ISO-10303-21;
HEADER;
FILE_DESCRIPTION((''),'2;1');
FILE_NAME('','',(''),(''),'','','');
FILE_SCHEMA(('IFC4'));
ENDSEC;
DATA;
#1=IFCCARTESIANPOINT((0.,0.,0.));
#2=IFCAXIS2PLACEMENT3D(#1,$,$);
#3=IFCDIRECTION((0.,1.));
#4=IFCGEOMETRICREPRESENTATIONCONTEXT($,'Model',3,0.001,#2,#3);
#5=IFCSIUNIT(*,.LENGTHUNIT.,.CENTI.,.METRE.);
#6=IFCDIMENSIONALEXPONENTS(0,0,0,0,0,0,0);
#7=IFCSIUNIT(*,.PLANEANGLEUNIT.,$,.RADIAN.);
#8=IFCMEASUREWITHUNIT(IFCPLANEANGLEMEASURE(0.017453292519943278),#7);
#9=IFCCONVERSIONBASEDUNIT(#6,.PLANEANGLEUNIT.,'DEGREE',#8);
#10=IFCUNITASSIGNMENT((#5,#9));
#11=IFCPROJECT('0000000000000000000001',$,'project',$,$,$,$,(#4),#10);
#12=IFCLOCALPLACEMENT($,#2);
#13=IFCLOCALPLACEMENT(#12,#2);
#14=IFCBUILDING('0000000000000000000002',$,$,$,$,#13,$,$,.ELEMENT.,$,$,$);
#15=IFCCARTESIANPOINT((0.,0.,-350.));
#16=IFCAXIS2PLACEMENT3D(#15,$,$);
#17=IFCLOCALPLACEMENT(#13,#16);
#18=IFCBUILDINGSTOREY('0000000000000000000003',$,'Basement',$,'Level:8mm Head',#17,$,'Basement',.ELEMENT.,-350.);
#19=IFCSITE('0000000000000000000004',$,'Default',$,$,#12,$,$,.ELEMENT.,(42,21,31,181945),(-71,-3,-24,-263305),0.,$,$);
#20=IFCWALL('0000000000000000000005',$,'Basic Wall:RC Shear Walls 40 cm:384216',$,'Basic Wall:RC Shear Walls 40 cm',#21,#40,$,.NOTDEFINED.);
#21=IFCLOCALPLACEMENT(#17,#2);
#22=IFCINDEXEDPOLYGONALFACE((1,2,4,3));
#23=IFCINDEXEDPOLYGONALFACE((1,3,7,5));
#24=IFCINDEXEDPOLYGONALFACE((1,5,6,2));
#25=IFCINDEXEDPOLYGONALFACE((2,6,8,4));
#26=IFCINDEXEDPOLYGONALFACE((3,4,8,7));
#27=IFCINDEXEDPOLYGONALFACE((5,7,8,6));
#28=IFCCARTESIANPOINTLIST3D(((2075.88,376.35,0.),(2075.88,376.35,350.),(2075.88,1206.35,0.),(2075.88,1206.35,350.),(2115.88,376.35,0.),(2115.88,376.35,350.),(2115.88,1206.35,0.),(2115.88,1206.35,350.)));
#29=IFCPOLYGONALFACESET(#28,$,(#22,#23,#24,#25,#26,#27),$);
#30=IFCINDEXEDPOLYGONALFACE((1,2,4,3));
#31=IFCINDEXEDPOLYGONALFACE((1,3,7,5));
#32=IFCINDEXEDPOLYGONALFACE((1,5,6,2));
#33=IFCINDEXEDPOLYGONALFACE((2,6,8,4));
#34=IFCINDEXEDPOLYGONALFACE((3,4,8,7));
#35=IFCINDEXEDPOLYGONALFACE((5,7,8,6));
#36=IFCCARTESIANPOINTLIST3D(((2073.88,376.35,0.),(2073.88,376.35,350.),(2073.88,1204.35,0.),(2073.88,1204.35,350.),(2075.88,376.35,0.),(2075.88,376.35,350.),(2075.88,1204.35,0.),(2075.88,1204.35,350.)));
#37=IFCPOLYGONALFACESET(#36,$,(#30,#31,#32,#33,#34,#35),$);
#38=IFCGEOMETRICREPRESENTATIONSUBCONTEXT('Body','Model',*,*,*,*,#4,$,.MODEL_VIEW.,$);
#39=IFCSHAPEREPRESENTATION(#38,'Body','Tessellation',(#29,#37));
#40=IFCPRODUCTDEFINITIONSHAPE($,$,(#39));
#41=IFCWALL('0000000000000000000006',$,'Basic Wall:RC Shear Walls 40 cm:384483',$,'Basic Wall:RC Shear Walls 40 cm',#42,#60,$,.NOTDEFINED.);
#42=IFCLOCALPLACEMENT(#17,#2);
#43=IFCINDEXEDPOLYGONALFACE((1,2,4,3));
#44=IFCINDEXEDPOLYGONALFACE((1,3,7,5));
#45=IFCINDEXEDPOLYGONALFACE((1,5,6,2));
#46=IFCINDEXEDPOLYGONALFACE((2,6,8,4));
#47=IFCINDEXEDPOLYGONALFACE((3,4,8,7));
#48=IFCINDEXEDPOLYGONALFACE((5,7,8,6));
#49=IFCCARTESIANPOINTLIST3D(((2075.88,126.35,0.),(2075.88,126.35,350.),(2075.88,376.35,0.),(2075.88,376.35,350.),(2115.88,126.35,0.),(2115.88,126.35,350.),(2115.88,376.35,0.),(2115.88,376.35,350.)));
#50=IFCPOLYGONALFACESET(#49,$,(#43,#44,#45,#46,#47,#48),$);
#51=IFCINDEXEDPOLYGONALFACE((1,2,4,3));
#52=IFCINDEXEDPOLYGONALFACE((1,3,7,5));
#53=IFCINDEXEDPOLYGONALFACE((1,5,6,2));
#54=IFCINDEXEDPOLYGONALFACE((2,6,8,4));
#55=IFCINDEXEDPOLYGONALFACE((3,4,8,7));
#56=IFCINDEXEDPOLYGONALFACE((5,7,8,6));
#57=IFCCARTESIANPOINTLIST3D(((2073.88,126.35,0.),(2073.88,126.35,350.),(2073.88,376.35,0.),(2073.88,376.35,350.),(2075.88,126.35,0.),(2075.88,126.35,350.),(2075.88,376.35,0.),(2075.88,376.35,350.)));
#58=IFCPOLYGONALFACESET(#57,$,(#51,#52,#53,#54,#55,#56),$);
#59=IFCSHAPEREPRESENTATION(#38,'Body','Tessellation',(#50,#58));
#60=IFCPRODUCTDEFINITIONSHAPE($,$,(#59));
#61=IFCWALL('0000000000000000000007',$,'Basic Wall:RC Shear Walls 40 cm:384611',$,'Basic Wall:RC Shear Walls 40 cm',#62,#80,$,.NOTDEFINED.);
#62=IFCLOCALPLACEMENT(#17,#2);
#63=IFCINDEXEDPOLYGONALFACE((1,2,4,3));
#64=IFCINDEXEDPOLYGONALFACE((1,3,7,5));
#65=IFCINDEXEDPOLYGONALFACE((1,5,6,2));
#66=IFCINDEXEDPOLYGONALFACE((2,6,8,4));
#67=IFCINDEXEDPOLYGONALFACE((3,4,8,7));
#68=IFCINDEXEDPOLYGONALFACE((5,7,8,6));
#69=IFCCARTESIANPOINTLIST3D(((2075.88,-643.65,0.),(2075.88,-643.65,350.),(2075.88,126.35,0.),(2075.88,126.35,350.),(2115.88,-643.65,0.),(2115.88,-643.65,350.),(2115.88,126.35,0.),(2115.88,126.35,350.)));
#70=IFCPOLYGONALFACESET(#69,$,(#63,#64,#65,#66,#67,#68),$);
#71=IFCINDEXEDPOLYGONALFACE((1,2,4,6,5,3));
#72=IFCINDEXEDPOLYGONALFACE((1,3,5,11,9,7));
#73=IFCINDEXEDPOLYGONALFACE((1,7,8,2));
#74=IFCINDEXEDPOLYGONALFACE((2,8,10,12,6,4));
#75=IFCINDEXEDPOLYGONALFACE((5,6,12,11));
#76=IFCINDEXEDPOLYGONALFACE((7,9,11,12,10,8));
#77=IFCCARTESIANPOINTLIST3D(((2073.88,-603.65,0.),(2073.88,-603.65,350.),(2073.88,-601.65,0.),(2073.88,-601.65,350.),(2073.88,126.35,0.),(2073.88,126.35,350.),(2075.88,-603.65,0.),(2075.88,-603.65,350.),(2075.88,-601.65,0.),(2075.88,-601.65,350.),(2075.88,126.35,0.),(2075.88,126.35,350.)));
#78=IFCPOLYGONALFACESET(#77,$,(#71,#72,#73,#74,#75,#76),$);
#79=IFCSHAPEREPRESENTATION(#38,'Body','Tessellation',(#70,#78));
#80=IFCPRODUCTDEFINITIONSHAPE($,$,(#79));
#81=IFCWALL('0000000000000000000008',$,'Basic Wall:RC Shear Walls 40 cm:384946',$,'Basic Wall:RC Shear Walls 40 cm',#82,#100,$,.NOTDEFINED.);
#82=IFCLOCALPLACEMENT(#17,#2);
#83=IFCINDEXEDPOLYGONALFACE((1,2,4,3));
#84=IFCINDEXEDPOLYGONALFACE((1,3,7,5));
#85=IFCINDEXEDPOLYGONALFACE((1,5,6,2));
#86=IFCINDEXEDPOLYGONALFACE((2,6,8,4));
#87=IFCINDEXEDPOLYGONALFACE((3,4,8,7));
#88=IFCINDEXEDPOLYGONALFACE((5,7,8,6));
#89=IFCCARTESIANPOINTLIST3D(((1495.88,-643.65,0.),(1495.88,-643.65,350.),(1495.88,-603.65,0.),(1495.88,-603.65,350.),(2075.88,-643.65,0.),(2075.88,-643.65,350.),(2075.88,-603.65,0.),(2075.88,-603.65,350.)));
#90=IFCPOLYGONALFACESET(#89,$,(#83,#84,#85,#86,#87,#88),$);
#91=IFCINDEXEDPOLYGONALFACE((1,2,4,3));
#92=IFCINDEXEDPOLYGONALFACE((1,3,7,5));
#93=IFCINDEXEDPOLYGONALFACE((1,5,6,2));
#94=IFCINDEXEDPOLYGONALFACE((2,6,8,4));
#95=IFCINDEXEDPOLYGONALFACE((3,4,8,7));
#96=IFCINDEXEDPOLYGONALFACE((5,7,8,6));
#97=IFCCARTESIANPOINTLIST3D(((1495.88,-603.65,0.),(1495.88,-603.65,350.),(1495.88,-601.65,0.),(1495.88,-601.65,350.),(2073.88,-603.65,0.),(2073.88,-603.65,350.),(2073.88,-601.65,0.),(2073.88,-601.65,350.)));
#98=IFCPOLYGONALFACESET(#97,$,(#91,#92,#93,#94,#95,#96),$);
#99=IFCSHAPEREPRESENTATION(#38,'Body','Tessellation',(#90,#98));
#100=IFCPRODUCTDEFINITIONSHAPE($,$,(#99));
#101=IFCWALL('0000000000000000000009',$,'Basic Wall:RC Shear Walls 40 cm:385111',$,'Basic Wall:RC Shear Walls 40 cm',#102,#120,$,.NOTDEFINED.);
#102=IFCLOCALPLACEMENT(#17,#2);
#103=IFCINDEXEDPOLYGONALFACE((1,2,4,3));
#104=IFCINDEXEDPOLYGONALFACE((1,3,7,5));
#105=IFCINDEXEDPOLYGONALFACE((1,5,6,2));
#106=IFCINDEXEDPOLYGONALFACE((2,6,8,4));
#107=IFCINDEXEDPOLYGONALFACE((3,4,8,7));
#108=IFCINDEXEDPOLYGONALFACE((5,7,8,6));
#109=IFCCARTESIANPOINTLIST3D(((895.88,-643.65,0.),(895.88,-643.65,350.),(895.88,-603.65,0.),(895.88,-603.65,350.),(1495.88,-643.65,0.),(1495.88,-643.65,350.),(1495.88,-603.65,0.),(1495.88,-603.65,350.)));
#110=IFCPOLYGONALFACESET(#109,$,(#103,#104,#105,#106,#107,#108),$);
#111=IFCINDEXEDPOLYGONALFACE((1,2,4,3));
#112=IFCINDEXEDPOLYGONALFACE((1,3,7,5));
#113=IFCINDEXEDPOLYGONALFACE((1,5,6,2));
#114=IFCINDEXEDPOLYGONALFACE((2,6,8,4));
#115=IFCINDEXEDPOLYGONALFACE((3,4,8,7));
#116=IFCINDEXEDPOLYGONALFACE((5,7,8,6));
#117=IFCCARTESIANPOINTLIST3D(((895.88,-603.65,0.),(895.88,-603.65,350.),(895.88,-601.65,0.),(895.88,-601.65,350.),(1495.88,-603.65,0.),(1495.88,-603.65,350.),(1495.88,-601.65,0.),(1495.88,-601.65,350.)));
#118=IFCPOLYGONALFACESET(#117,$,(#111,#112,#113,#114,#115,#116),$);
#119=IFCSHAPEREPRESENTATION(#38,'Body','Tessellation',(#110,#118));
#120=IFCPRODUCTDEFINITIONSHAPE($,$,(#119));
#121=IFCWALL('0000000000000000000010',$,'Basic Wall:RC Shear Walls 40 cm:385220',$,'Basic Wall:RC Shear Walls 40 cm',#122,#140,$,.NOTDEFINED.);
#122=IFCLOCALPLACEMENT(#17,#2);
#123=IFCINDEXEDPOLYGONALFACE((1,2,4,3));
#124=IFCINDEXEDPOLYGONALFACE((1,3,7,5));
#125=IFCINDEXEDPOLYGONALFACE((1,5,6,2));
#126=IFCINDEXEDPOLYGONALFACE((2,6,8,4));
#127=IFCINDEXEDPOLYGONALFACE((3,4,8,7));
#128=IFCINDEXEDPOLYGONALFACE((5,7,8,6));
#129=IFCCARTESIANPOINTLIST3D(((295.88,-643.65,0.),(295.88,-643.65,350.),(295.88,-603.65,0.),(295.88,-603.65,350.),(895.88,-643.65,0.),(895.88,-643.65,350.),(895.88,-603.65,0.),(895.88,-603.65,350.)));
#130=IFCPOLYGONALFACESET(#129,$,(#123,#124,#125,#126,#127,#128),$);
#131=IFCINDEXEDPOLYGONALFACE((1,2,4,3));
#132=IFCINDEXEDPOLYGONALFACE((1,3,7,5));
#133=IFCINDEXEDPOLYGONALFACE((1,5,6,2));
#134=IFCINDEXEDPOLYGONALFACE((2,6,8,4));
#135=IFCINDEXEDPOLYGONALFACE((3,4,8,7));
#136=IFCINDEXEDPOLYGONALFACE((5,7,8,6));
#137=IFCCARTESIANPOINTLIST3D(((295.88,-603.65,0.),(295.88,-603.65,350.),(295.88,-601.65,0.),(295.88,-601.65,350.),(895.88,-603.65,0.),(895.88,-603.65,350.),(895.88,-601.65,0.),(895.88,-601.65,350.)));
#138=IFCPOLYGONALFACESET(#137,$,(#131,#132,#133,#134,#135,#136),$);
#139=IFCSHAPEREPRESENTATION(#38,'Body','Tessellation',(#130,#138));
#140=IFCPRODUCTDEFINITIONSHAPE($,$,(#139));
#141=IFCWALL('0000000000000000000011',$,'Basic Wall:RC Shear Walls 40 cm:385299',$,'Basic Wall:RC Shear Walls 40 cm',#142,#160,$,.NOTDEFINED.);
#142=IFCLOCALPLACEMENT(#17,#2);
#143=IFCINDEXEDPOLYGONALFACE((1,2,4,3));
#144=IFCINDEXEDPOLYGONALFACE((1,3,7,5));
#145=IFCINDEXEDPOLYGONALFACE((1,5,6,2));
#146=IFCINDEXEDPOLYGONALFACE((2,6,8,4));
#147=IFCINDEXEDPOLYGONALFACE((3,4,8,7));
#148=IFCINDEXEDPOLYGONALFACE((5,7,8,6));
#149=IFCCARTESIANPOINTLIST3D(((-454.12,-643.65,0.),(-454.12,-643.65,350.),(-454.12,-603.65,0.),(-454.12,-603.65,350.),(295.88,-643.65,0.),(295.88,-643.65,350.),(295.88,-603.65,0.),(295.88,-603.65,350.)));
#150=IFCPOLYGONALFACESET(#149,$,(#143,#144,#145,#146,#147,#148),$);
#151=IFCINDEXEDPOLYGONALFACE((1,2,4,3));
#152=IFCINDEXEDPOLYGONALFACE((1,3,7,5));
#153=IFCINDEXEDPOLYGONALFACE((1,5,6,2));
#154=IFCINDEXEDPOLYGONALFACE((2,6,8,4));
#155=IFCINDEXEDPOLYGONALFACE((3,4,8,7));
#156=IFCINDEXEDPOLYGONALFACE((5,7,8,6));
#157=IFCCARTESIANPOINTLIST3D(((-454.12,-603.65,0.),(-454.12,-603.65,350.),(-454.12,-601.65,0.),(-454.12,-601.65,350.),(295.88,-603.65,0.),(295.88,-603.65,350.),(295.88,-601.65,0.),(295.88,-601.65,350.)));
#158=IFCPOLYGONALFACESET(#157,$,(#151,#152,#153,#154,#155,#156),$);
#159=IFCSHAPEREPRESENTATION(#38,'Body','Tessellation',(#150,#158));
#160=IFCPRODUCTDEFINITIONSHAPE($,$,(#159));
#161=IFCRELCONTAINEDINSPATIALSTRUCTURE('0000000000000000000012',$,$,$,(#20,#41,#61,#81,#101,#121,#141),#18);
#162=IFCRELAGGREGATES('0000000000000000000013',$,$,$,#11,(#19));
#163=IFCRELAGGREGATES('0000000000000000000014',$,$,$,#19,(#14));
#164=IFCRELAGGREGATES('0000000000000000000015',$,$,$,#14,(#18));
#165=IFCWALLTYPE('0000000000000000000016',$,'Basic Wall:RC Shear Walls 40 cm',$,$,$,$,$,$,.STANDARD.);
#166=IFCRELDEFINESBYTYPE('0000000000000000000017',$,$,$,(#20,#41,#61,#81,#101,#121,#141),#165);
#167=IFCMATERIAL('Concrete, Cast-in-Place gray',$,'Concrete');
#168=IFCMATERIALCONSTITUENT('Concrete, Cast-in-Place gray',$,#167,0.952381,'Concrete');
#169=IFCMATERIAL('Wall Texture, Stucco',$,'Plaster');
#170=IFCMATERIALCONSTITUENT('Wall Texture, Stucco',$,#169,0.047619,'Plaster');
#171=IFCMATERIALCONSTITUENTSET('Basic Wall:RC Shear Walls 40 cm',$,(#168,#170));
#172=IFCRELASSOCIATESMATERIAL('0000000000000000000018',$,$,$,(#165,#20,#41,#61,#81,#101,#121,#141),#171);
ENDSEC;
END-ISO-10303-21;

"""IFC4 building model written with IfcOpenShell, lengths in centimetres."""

from ifc_helpers import new_model, entity, si_unit, converted_unit, direction, frame, origin, place, context, subcontext, project, spatial, indexed_curve, outline, extrude, material, constituent, constituent_set, type_object, element, save


model = new_model("IFC4")

# Units and contexts
model_context = context("Model", 3, precision=0.001, world=origin(), true_north=direction((0.0, 1.0)))
body_context = subcontext(model_context, "Body", "Model", "MODEL_VIEW")
ifc_project = project(units=[si_unit("LENGTHUNIT", "METRE", prefix="CENTI"), converted_unit("PLANEANGLEUNIT", "DEGREE", entity("IfcPlaneAngleMeasure", 0.017453292519943278), si_unit("PLANEANGLEUNIT", "RADIAN"), dimensions=[0, 0, 0, 0, 0, 0, 0])], contexts=[model_context])

# Site, building, storey
site_placement = place(None, origin())
site = spatial("IfcSite", under=ifc_project, at=site_placement, Name="Default", CompositionType="ELEMENT", RefLatitude=(42, 21, 31, 181945), RefLongitude=(-71, -3, -24, -263305), RefElevation=0.0)
building_placement = place(site_placement, origin())
building = spatial("IfcBuilding", under=site, at=building_placement, CompositionType="ELEMENT")
storey_placement = place(building_placement, frame((0.0, 0.0, -350.0)))
storey = spatial("IfcBuildingStorey", under=building, at=storey_placement, Name="Basement", ObjectType="Level:8mm Head", LongName="Basement", CompositionType="ELEMENT", Elevation=-350.0)

# Shared definitions
ifc_material_1 = material(Name="Concrete, Cast-in-Place gray", Category="Concrete")

# Walls
ifc_constituent_1 = constituent(ifc_material_1, Name="Concrete, Cast-in-Place gray", Category="Concrete", fraction=0.952381)
ifc_material_2 = material(Name="Wall Texture, Stucco", Category="Plaster")
ifc_constituent_2 = constituent(ifc_material_2, Name="Wall Texture, Stucco", Category="Plaster", fraction=0.047619)
ifc_constituent_set_1 = constituent_set(constituents=[ifc_constituent_1, ifc_constituent_2], Name="Basic Wall:RC Shear Walls 40 cm")
wall_type_1 = type_object("IfcWallType", Name="Basic Wall:RC Shear Walls 40 cm", PredefinedType="STANDARD", material=ifc_constituent_set_1)
wall_1_placement = place(storey_placement, frame((2094.88, 1204.35, 0.0), z_axis=(0.0, 0.0, 1.0), x_axis=(0.0, -1.0, 0.0)))
element("IfcWall", 1, at=wall_1_placement, inside=storey, type_object=wall_type_1, material=ifc_constituent_set_1, Name="Basic Wall:RC Shear Walls 40 cm:384216", ObjectType="Basic Wall:RC Shear Walls 40 cm", PredefinedType="NOTDEFINED", context=body_context, shape_type="SweptSolid", body=[
    extrude(outline(indexed_curve([(-20.0, -415.0), (20.0, -415.0), (20.0, 415.0), (-20.0, 415.0), (-20.0, -415.0)], self_intersect=False)), frame((413.0, 1.0, 0.0), z_axis=(0.0, 0.0, 1.0), x_axis=(0.0, -1.0, 0.0)), (0.0, 0.0, 1.0), 350.0),
    extrude(outline(indexed_curve([(-1.0, -414.0), (1.0, -414.0), (1.0, 414.0), (-1.0, 414.0), (-1.0, -414.0)], self_intersect=False)), frame((414.0, -20.0, 0.0), z_axis=(0.0, 0.0, 1.0), x_axis=(0.0, 1.0, 0.0)), (0.0, 0.0, 1.0), 350.0),
])
wall_2_placement = place(storey_placement, frame((2094.88, 376.35, 0.0), z_axis=(0.0, 0.0, 1.0), x_axis=(0.0, -1.0, 0.0)))
element("IfcWall", 2, at=wall_2_placement, inside=storey, type_object=wall_type_1, material=ifc_constituent_set_1, Name="Basic Wall:RC Shear Walls 40 cm:384483", ObjectType="Basic Wall:RC Shear Walls 40 cm", PredefinedType="NOTDEFINED", context=body_context, shape_type="SweptSolid", body=[
    extrude(outline(indexed_curve([(-20.0, -125.0), (20.0, -125.0), (20.0, 125.0), (-20.0, 125.0), (-20.0, -125.0)], self_intersect=False)), frame((125.0, 1.0, 0.0), z_axis=(0.0, 0.0, 1.0), x_axis=(0.0, -1.0, 0.0)), (0.0, 0.0, 1.0), 350.0),
    extrude(outline(indexed_curve([(-1.0, -125.0), (1.0, -125.0), (1.0, 125.0), (-1.0, 125.0), (-1.0, -125.0)], self_intersect=False)), frame((125.0, -20.0, 0.0), z_axis=(0.0, 0.0, 1.0), x_axis=(0.0, 1.0, 0.0)), (0.0, 0.0, 1.0), 350.0),
])
wall_3_placement = place(storey_placement, frame((2094.88, 126.35, 0.0), z_axis=(0.0, 0.0, 1.0), x_axis=(0.0, -1.0, 0.0)))
element("IfcWall", 3, at=wall_3_placement, inside=storey, type_object=wall_type_1, material=ifc_constituent_set_1, Name="Basic Wall:RC Shear Walls 40 cm:384611", ObjectType="Basic Wall:RC Shear Walls 40 cm", PredefinedType="NOTDEFINED", context=body_context, shape_type="SweptSolid", body=[
    extrude(outline(indexed_curve([(-20.0, -385.0), (20.0, -385.0), (20.0, 385.0), (-20.0, 385.0), (-20.0, -385.0)], self_intersect=False)), frame((385.0, 1.0, 0.0), z_axis=(0.0, 0.0, 1.0), x_axis=(0.0, -1.0, 0.0)), (0.0, 0.0, 1.0), 350.0),
    extrude(outline(indexed_curve([(-175.0, -486.0), (175.0, -486.0), (175.0, 242.0), (175.0, 244.0), (-175.0, 244.0), (-175.0, 242.0), (-175.0, -486.0)], self_intersect=False)), frame((486.0, -21.0, 175.0), z_axis=(0.0, 1.0, 0.0), x_axis=(0.0, 0.0, 1.0)), (0.0, 0.0, 1.0), 2.0),
])
wall_4_placement = place(storey_placement, frame((2073.88, -622.65, 0.0), z_axis=(0.0, 0.0, 1.0), x_axis=(-1.0, 0.0, 0.0)))
element("IfcWall", 4, at=wall_4_placement, inside=storey, type_object=wall_type_1, material=ifc_constituent_set_1, Name="Basic Wall:RC Shear Walls 40 cm:384946", ObjectType="Basic Wall:RC Shear Walls 40 cm", PredefinedType="NOTDEFINED", context=body_context, shape_type="SweptSolid", body=[
    extrude(outline(indexed_curve([(-20.0, -290.0), (20.0, -290.0), (20.0, 290.0), (-20.0, 290.0), (-20.0, -290.0)], self_intersect=False)), frame((288.0, 1.0, 0.0), z_axis=(0.0, 0.0, 1.0), x_axis=(0.0, -1.0, 0.0)), (0.0, 0.0, 1.0), 350.0),
    extrude(outline(indexed_curve([(-1.0, -289.0), (1.0, -289.0), (1.0, 289.0), (-1.0, 289.0), (-1.0, -289.0)], self_intersect=False)), frame((289.0, -20.0, 0.0), z_axis=(0.0, 0.0, 1.0), x_axis=(0.0, 1.0, 0.0)), (0.0, 0.0, 1.0), 350.0),
])
wall_5_placement = place(storey_placement, frame((1495.88, -622.65, 0.0), z_axis=(0.0, 0.0, 1.0), x_axis=(-1.0, 0.0, 0.0)))
element("IfcWall", 5, at=wall_5_placement, inside=storey, type_object=wall_type_1, material=ifc_constituent_set_1, Name="Basic Wall:RC Shear Walls 40 cm:385111", ObjectType="Basic Wall:RC Shear Walls 40 cm", PredefinedType="NOTDEFINED", context=body_context, shape_type="SweptSolid", body=[
    extrude(outline(indexed_curve([(-20.0, -300.0), (20.0, -300.0), (20.0, 300.0), (-20.0, 300.0), (-20.0, -300.0)], self_intersect=False)), frame((300.0, 1.0, 0.0), z_axis=(0.0, 0.0, 1.0), x_axis=(0.0, -1.0, 0.0)), (0.0, 0.0, 1.0), 350.0),
    extrude(outline(indexed_curve([(-1.0, -300.0), (1.0, -300.0), (1.0, 300.0), (-1.0, 300.0), (-1.0, -300.0)], self_intersect=False)), frame((300.0, -20.0, 0.0), z_axis=(0.0, 0.0, 1.0), x_axis=(0.0, 1.0, 0.0)), (0.0, 0.0, 1.0), 350.0),
])
wall_6_placement = place(storey_placement, frame((895.88, -622.65, 0.0), z_axis=(0.0, 0.0, 1.0), x_axis=(-1.0, 0.0, 0.0)))
element("IfcWall", 6, at=wall_6_placement, inside=storey, type_object=wall_type_1, material=ifc_constituent_set_1, Name="Basic Wall:RC Shear Walls 40 cm:385220", ObjectType="Basic Wall:RC Shear Walls 40 cm", PredefinedType="NOTDEFINED", context=body_context, shape_type="SweptSolid", body=[
    extrude(outline(indexed_curve([(-20.0, -300.0), (20.0, -300.0), (20.0, 300.0), (-20.0, 300.0), (-20.0, -300.0)], self_intersect=False)), frame((300.0, 1.0, 0.0), z_axis=(0.0, 0.0, 1.0), x_axis=(0.0, -1.0, 0.0)), (0.0, 0.0, 1.0), 350.0),
    extrude(outline(indexed_curve([(-1.0, -300.0), (1.0, -300.0), (1.0, 300.0), (-1.0, 300.0), (-1.0, -300.0)], self_intersect=False)), frame((300.0, -20.0, 0.0), z_axis=(0.0, 0.0, 1.0), x_axis=(0.0, 1.0, 0.0)), (0.0, 0.0, 1.0), 350.0),
])
wall_7_placement = place(storey_placement, frame((295.88, -622.65, 0.0), z_axis=(0.0, 0.0, 1.0), x_axis=(-1.0, 0.0, 0.0)))
element("IfcWall", 7, at=wall_7_placement, inside=storey, type_object=wall_type_1, material=ifc_constituent_set_1, Name="Basic Wall:RC Shear Walls 40 cm:385299", ObjectType="Basic Wall:RC Shear Walls 40 cm", PredefinedType="NOTDEFINED", context=body_context, shape_type="SweptSolid", body=[
    extrude(outline(indexed_curve([(-20.0, -375.0), (20.0, -375.0), (20.0, 375.0), (-20.0, 375.0), (-20.0, -375.0)], self_intersect=False)), frame((375.0, 1.0, 0.0), z_axis=(0.0, 0.0, 1.0), x_axis=(0.0, -1.0, 0.0)), (0.0, 0.0, 1.0), 350.0),
    extrude(outline(indexed_curve([(-1.0, -375.0), (1.0, -375.0), (1.0, 375.0), (-1.0, 375.0), (-1.0, -375.0)], self_intersect=False)), frame((375.0, -20.0, 0.0), z_axis=(0.0, 0.0, 1.0), x_axis=(0.0, 1.0, 0.0)), (0.0, 0.0, 1.0), 350.0),
])

save(model, "model.ifc")
